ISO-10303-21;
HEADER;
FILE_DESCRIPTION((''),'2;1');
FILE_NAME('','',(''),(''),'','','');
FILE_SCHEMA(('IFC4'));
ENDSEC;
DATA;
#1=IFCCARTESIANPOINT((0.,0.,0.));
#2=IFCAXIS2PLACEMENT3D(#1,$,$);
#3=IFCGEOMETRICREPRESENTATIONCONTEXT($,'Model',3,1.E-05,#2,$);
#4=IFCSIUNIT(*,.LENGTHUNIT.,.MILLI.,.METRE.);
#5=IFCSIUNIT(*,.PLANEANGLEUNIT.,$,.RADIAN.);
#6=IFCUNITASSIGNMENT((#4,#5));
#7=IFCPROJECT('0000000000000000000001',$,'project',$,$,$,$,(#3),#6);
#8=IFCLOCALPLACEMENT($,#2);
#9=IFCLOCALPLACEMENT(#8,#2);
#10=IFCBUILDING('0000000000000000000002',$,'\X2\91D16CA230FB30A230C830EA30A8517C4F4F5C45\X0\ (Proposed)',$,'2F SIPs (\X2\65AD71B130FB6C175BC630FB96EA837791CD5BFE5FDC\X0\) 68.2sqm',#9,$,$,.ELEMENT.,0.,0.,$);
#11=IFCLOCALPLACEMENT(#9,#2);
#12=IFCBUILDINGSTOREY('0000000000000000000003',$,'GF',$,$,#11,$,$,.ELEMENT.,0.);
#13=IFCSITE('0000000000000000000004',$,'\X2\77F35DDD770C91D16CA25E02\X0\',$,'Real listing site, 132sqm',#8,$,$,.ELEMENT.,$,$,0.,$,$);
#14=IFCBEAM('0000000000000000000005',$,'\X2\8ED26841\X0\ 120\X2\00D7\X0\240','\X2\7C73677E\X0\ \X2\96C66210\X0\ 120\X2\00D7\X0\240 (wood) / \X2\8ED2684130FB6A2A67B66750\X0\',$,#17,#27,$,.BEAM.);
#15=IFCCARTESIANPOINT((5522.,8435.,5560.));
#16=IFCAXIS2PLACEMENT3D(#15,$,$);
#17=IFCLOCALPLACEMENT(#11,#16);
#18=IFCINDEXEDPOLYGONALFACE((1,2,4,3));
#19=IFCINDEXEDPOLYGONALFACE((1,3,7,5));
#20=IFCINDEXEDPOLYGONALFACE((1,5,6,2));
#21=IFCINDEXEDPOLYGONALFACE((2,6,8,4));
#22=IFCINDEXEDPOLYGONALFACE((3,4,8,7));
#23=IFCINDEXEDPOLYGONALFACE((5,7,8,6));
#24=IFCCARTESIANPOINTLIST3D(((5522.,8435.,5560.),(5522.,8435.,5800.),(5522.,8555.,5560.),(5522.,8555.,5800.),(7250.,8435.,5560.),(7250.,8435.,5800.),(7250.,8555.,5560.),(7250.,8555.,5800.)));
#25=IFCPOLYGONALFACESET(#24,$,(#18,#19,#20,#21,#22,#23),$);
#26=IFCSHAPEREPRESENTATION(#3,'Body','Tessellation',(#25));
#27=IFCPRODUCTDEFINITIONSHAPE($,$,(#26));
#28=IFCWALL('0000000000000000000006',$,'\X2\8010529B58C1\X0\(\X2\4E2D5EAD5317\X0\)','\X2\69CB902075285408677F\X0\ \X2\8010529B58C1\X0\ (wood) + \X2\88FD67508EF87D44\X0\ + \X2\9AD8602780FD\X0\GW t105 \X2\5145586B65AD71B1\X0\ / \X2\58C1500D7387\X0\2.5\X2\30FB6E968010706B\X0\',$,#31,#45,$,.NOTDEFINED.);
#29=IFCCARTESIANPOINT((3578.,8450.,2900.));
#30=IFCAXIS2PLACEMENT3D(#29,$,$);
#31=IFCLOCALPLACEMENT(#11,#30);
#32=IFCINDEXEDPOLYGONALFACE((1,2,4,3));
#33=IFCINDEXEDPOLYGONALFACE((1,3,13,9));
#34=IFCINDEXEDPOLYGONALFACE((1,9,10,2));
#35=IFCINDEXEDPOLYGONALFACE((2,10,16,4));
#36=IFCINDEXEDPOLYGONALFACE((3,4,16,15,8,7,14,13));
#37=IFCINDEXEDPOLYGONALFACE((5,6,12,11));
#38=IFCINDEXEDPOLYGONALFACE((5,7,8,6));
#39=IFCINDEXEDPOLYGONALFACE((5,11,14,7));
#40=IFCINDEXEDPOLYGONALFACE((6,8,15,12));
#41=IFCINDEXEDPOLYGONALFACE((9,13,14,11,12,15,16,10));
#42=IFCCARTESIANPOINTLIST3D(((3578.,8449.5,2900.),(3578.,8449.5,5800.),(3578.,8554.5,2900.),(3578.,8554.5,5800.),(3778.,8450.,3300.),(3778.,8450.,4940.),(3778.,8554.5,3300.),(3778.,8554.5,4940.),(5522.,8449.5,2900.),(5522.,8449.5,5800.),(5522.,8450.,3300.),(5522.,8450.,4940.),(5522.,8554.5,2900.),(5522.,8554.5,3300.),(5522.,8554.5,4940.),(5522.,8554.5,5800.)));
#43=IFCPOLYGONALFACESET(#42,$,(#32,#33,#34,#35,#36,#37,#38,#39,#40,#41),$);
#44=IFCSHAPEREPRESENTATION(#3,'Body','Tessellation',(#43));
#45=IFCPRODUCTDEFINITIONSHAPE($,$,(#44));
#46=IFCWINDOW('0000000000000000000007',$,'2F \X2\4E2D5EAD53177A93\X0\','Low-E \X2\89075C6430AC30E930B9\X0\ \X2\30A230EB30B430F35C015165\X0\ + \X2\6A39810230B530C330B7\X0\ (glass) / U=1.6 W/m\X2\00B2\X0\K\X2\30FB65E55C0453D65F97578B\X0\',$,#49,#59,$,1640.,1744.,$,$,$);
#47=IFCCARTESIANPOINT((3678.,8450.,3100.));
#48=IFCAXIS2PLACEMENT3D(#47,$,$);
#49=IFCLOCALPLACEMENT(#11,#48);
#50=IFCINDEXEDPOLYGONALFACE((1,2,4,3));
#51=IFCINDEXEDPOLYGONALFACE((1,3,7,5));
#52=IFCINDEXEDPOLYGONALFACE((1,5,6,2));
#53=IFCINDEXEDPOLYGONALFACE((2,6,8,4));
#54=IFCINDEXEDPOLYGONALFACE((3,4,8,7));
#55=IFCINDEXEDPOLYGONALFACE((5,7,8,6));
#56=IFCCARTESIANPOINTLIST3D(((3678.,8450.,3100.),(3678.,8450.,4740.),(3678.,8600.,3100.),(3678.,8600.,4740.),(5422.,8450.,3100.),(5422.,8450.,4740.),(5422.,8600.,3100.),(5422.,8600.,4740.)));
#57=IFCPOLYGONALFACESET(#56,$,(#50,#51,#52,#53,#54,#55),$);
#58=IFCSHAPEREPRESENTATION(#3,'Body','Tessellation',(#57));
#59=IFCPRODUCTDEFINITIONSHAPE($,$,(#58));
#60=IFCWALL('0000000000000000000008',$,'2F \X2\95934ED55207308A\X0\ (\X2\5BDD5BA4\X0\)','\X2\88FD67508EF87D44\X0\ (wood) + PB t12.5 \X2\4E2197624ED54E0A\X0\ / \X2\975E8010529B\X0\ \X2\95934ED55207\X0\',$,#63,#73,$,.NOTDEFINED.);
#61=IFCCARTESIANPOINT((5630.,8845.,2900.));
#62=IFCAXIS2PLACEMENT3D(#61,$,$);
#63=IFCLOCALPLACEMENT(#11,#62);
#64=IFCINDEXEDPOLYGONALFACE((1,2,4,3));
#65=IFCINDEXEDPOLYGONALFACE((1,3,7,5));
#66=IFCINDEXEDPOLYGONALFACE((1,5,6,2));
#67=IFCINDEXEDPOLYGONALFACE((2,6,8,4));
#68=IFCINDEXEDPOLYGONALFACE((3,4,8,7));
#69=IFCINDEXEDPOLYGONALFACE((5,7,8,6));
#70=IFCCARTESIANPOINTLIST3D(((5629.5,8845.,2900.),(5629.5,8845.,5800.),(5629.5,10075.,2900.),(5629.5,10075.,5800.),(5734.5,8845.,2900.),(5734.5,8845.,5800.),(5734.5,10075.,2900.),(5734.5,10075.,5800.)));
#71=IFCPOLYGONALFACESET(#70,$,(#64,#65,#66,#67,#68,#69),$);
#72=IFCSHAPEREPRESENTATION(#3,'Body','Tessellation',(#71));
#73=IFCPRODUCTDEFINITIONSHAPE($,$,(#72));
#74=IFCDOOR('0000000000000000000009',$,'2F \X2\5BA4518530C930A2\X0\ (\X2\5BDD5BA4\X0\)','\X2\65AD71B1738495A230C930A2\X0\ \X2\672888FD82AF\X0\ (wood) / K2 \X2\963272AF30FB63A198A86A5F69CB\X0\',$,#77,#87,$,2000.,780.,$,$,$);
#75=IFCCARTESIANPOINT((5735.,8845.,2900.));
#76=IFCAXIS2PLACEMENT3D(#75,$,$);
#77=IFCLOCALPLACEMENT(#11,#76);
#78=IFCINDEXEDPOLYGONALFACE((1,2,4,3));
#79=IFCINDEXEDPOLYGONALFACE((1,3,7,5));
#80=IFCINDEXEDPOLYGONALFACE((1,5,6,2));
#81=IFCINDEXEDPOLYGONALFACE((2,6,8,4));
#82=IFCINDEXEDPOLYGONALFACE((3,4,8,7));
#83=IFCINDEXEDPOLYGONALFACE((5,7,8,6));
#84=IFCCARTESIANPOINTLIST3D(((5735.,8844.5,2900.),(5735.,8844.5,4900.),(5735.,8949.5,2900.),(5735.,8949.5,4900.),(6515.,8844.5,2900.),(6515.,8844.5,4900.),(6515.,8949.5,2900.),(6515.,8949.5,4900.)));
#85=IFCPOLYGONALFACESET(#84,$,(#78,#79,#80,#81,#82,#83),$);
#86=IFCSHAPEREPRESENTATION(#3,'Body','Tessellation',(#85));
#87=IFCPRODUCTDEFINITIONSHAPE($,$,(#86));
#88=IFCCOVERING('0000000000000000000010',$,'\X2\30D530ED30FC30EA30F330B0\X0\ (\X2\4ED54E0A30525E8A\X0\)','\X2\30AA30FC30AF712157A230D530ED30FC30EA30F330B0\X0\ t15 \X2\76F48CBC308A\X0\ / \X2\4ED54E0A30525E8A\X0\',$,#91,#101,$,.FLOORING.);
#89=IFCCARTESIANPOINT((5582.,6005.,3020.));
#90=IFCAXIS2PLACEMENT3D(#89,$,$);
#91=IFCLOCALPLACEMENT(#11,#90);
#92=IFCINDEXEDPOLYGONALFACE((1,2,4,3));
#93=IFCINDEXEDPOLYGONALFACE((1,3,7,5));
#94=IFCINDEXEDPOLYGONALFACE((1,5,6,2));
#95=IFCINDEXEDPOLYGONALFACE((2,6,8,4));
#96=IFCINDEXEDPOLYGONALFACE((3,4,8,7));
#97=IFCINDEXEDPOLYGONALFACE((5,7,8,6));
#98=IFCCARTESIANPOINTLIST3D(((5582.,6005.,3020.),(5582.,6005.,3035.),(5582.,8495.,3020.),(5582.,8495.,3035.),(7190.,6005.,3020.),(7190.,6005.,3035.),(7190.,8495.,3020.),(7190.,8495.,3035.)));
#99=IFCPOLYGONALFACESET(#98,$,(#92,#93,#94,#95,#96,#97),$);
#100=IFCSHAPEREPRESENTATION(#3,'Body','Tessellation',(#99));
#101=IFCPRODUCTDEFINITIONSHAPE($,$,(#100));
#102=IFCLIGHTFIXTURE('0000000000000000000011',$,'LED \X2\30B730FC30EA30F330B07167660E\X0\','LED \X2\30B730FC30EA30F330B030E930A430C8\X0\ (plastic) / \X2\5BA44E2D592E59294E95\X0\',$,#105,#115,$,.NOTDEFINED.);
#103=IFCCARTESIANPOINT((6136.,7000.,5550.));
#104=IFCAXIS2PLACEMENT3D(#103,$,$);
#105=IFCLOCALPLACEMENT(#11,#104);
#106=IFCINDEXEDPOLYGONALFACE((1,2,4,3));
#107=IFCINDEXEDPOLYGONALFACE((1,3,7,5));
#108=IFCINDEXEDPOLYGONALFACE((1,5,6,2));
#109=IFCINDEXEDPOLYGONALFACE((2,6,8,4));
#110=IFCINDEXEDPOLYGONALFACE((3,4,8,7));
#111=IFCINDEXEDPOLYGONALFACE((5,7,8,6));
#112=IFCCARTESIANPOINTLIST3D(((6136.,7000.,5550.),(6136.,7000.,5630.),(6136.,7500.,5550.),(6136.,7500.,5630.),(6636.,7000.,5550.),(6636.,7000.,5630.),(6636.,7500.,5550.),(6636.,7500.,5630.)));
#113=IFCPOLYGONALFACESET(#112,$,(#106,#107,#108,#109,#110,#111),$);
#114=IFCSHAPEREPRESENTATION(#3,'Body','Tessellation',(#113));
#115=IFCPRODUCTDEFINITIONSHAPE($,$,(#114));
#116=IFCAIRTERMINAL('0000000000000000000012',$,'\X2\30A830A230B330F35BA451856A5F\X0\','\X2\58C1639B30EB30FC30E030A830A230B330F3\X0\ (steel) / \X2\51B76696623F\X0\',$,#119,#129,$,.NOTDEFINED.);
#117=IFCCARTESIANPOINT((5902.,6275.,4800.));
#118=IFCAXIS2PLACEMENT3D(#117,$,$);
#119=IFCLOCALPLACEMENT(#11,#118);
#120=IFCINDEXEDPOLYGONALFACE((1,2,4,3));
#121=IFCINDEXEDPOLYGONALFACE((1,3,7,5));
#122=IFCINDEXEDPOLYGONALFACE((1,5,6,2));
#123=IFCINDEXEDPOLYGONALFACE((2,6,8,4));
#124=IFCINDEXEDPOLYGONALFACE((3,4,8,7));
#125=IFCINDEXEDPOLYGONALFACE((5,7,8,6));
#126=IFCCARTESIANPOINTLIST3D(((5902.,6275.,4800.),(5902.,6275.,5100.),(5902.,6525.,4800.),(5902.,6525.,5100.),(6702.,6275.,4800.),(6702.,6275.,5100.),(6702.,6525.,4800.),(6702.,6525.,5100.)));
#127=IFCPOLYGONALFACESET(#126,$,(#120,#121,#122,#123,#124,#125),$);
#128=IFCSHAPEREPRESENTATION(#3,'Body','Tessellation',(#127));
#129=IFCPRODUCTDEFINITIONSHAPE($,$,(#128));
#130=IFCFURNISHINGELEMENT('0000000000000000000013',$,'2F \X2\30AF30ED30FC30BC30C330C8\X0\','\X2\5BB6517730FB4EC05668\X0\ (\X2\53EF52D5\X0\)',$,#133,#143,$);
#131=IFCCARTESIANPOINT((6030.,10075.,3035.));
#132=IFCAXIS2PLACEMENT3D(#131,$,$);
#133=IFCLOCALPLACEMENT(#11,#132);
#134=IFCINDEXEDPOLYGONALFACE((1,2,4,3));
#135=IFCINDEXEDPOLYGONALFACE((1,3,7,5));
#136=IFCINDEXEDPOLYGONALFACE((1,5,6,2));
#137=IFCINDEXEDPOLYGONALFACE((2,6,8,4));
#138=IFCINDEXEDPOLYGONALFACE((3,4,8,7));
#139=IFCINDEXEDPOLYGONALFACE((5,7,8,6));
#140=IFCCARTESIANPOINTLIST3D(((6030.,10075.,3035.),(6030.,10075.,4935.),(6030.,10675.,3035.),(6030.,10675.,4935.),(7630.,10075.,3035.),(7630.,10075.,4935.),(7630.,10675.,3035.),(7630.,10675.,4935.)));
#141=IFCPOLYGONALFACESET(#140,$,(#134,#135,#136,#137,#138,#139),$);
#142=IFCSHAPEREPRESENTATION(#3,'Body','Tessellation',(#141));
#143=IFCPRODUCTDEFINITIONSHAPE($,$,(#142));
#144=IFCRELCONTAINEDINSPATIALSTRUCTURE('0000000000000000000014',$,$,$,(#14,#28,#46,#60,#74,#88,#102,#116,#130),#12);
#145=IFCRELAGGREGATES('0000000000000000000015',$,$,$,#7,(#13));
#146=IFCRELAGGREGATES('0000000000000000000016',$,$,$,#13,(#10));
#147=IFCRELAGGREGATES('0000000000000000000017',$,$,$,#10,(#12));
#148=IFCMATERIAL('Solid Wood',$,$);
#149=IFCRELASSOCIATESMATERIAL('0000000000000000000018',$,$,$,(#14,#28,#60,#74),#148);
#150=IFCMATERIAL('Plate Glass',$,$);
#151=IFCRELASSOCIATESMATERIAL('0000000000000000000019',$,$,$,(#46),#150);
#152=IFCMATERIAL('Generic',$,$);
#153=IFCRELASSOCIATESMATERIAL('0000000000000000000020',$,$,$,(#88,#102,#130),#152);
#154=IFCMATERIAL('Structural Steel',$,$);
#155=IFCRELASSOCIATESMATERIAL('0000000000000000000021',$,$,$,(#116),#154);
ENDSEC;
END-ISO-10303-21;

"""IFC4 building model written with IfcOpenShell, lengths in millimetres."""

from ifc_helpers import new_model, si_unit, frame, frame_2d, origin, place, context, project, spatial, rectangle, extrude, material, element, fill, save


model = new_model("IFC4")

# Units and contexts
model_context = context("Model", 3, precision=1e-05, world=origin())
ifc_project = project(units=[si_unit("LENGTHUNIT", "METRE", prefix="MILLI"), si_unit("PLANEANGLEUNIT", "RADIAN")], contexts=[model_context])

# Site, building, storey
site_placement = place(None, origin())
site = spatial("IfcSite", under=ifc_project, at=site_placement, Name="石川県金沢市", ObjectType="Real listing site, 132sqm", CompositionType="ELEMENT", RefElevation=0.0)
building_placement = place(site_placement, origin())
building = spatial("IfcBuilding", under=site, at=building_placement, Name="金沢・アトリエ兼住居 (Proposed)", ObjectType="2F SIPs (断熱・気密・雪荷重対応) 68.2sqm", CompositionType="ELEMENT", ElevationOfRefHeight=0.0, ElevationOfTerrain=0.0)
storey_placement = place(building_placement, origin())
storey = spatial("IfcBuildingStorey", under=building, at=storey_placement, Name="GF", CompositionType="ELEMENT", Elevation=0.0)

# Shared definitions
ifc_material_1 = material(Name="Solid Wood")

# Beam
beam_1_placement = place(storey_placement, frame((5522.0, 8435.0, 5560.0)))
element("IfcBeam", 1, at=beam_1_placement, inside=storey, material=ifc_material_1, Name="軒桁 120×240", Description="米松 集成 120×240 (wood) / 軒桁・横架材", PredefinedType="BEAM", context=model_context, shape_type="SweptSolid", body=[
    extrude(rectangle(XDim=1728.0, YDim=120.0, at=frame_2d((864.0, 60.0))), frame((5522.0, 8435.0, 5560.0)), (0.0, 0.0, 1.0), 240.0),
])

# Wall, opening, window
wall_1_placement = place(storey_placement, frame((3578.0, 8450.0, 2900.0)))
wall_1 = element("IfcWall", 2, at=wall_1_placement, inside=storey, material=ifc_material_1, Name="耐力壁(中庭北)", Description="構造用合板 耐力壁 (wood) + 製材軸組 + 高性能GW t105 充填断熱 / 壁倍率2.5・準耐火", PredefinedType="NOTDEFINED", context=model_context, shape_type="SweptSolid", body=[
    extrude(rectangle(XDim=1944.0, YDim=105.0, at=frame_2d((972.0, 52.0))), frame((3578.0, 8450.0, 2900.0)), (0.0, 0.0, 1.0), 2900.0),
])
opening_placement = place(storey_placement, frame((3678.0, 8450.0, 3100.0)))
opening = element("IfcOpeningElement", 3, at=opening_placement, cuts=wall_1, PredefinedType="NOTDEFINED", context=model_context, shape_type="SweptSolid", body=[
    extrude(rectangle(XDim=1744.0, YDim=150.0, at=frame_2d((872.0, 75.0))), frame((3678.0, 8450.0, 3100.0)), (0.0, 0.0, 1.0), 1640.0),
])
ifc_material_2 = material(Name="Plate Glass")
window_placement = place(storey_placement, frame((3678.0, 8450.0, 3100.0)))
window = element("IfcWindow", 4, at=window_placement, inside=storey, material=ifc_material_2, Name="2F 中庭北窓", Description="Low-E 複層ガラス アルゴン封入 + 樹脂サッシ (glass) / U=1.6 W/m²K・日射取得型", OverallHeight=1640.0, OverallWidth=1744.0, context=model_context, shape_type="SweptSolid", body=[
    extrude(rectangle(XDim=1744.0, YDim=150.0, at=frame_2d((872.0, 75.0))), frame((3678.0, 8450.0, 3100.0)), (0.0, 0.0, 1.0), 1640.0),
])
fill(opening, window)

# Wall
wall_2_placement = place(storey_placement, frame((5630.0, 8845.0, 2900.0)))
element("IfcWall", 5, at=wall_2_placement, inside=storey, material=ifc_material_1, Name="2F 間仕切り (寝室)", Description="製材軸組 (wood) + PB t12.5 両面仕上 / 非耐力 間仕切", PredefinedType="NOTDEFINED", context=model_context, shape_type="SweptSolid", body=[
    extrude(rectangle(XDim=105.0, YDim=1230.0, at=frame_2d((52.0, 615.0))), frame((5630.0, 8845.0, 2900.0)), (0.0, 0.0, 1.0), 2900.0),
])

# Door
door_placement = place(storey_placement, frame((5735.0, 8845.0, 2900.0)))
element("IfcDoor", 6, at=door_placement, inside=storey, material=ifc_material_1, Name="2F 室内ドア (寝室)", Description="断熱玄関ドア 木製芯 (wood) / K2 防犯・採風機構", OverallHeight=2000.0, OverallWidth=780.0, context=model_context, shape_type="SweptSolid", body=[
    extrude(rectangle(XDim=780.0, YDim=105.0, at=frame_2d((390.0, 52.0))), frame((5735.0, 8845.0, 2900.0)), (0.0, 0.0, 1.0), 2000.0),
])

# Covering
ifc_material_3 = material(Name="Generic")
covering_placement = place(storey_placement, frame((5582.0, 6005.0, 3020.0)))
element("IfcCovering", 7, at=covering_placement, inside=storey, material=ifc_material_3, Name="フローリング (仕上げ床)", Description="オーク無垢フローリング t15 直貼り / 仕上げ床", PredefinedType="FLOORING", context=model_context, shape_type="SweptSolid", body=[
    extrude(rectangle(XDim=1608.0, YDim=2490.0, at=frame_2d((804.0, 1245.0))), frame((5582.0, 6005.0, 3020.0)), (0.0, 0.0, 1.0), 15.0),
])

# Light fixture
light_fixture_placement = place(storey_placement, frame((6136.0, 7000.0, 5550.0)))
element("IfcLightFixture", 8, at=light_fixture_placement, inside=storey, material=ifc_material_3, Name="LED シーリング照明", Description="LED シーリングライト (plastic) / 室中央天井", PredefinedType="NOTDEFINED", context=model_context, shape_type="SweptSolid", body=[
    extrude(rectangle(XDim=500.0, YDim=500.0, at=frame_2d((250.0, 250.0))), frame((6136.0, 7000.0, 5550.0)), (0.0, 0.0, 1.0), 80.0),
])

# Air terminal
ifc_material_4 = material(Name="Structural Steel")
air_terminal_placement = place(storey_placement, frame((5902.0, 6275.0, 4800.0)))
element("IfcAirTerminal", 9, at=air_terminal_placement, inside=storey, material=ifc_material_4, Name="エアコン室内機", Description="壁掛ルームエアコン (steel) / 冷暖房", PredefinedType="NOTDEFINED", context=model_context, shape_type="SweptSolid", body=[
    extrude(rectangle(XDim=800.0, YDim=250.0, at=frame_2d((400.0, 125.0))), frame((5902.0, 6275.0, 4800.0)), (0.0, 0.0, 1.0), 300.0),
])

# Furnishing element
furnishing_placement = place(storey_placement, frame((6030.0, 10075.0, 3035.0)))
element("IfcFurnishingElement", 10, at=furnishing_placement, inside=storey, material=ifc_material_3, Name="2F クローゼット", Description="家具・什器 (可動)", context=model_context, shape_type="SweptSolid", body=[
    extrude(rectangle(XDim=1600.0, YDim=600.0, at=frame_2d((800.0, 300.0))), frame((6030.0, 10075.0, 3035.0)), (0.0, 0.0, 1.0), 1900.0),
])

save(model, "model.ifc")
